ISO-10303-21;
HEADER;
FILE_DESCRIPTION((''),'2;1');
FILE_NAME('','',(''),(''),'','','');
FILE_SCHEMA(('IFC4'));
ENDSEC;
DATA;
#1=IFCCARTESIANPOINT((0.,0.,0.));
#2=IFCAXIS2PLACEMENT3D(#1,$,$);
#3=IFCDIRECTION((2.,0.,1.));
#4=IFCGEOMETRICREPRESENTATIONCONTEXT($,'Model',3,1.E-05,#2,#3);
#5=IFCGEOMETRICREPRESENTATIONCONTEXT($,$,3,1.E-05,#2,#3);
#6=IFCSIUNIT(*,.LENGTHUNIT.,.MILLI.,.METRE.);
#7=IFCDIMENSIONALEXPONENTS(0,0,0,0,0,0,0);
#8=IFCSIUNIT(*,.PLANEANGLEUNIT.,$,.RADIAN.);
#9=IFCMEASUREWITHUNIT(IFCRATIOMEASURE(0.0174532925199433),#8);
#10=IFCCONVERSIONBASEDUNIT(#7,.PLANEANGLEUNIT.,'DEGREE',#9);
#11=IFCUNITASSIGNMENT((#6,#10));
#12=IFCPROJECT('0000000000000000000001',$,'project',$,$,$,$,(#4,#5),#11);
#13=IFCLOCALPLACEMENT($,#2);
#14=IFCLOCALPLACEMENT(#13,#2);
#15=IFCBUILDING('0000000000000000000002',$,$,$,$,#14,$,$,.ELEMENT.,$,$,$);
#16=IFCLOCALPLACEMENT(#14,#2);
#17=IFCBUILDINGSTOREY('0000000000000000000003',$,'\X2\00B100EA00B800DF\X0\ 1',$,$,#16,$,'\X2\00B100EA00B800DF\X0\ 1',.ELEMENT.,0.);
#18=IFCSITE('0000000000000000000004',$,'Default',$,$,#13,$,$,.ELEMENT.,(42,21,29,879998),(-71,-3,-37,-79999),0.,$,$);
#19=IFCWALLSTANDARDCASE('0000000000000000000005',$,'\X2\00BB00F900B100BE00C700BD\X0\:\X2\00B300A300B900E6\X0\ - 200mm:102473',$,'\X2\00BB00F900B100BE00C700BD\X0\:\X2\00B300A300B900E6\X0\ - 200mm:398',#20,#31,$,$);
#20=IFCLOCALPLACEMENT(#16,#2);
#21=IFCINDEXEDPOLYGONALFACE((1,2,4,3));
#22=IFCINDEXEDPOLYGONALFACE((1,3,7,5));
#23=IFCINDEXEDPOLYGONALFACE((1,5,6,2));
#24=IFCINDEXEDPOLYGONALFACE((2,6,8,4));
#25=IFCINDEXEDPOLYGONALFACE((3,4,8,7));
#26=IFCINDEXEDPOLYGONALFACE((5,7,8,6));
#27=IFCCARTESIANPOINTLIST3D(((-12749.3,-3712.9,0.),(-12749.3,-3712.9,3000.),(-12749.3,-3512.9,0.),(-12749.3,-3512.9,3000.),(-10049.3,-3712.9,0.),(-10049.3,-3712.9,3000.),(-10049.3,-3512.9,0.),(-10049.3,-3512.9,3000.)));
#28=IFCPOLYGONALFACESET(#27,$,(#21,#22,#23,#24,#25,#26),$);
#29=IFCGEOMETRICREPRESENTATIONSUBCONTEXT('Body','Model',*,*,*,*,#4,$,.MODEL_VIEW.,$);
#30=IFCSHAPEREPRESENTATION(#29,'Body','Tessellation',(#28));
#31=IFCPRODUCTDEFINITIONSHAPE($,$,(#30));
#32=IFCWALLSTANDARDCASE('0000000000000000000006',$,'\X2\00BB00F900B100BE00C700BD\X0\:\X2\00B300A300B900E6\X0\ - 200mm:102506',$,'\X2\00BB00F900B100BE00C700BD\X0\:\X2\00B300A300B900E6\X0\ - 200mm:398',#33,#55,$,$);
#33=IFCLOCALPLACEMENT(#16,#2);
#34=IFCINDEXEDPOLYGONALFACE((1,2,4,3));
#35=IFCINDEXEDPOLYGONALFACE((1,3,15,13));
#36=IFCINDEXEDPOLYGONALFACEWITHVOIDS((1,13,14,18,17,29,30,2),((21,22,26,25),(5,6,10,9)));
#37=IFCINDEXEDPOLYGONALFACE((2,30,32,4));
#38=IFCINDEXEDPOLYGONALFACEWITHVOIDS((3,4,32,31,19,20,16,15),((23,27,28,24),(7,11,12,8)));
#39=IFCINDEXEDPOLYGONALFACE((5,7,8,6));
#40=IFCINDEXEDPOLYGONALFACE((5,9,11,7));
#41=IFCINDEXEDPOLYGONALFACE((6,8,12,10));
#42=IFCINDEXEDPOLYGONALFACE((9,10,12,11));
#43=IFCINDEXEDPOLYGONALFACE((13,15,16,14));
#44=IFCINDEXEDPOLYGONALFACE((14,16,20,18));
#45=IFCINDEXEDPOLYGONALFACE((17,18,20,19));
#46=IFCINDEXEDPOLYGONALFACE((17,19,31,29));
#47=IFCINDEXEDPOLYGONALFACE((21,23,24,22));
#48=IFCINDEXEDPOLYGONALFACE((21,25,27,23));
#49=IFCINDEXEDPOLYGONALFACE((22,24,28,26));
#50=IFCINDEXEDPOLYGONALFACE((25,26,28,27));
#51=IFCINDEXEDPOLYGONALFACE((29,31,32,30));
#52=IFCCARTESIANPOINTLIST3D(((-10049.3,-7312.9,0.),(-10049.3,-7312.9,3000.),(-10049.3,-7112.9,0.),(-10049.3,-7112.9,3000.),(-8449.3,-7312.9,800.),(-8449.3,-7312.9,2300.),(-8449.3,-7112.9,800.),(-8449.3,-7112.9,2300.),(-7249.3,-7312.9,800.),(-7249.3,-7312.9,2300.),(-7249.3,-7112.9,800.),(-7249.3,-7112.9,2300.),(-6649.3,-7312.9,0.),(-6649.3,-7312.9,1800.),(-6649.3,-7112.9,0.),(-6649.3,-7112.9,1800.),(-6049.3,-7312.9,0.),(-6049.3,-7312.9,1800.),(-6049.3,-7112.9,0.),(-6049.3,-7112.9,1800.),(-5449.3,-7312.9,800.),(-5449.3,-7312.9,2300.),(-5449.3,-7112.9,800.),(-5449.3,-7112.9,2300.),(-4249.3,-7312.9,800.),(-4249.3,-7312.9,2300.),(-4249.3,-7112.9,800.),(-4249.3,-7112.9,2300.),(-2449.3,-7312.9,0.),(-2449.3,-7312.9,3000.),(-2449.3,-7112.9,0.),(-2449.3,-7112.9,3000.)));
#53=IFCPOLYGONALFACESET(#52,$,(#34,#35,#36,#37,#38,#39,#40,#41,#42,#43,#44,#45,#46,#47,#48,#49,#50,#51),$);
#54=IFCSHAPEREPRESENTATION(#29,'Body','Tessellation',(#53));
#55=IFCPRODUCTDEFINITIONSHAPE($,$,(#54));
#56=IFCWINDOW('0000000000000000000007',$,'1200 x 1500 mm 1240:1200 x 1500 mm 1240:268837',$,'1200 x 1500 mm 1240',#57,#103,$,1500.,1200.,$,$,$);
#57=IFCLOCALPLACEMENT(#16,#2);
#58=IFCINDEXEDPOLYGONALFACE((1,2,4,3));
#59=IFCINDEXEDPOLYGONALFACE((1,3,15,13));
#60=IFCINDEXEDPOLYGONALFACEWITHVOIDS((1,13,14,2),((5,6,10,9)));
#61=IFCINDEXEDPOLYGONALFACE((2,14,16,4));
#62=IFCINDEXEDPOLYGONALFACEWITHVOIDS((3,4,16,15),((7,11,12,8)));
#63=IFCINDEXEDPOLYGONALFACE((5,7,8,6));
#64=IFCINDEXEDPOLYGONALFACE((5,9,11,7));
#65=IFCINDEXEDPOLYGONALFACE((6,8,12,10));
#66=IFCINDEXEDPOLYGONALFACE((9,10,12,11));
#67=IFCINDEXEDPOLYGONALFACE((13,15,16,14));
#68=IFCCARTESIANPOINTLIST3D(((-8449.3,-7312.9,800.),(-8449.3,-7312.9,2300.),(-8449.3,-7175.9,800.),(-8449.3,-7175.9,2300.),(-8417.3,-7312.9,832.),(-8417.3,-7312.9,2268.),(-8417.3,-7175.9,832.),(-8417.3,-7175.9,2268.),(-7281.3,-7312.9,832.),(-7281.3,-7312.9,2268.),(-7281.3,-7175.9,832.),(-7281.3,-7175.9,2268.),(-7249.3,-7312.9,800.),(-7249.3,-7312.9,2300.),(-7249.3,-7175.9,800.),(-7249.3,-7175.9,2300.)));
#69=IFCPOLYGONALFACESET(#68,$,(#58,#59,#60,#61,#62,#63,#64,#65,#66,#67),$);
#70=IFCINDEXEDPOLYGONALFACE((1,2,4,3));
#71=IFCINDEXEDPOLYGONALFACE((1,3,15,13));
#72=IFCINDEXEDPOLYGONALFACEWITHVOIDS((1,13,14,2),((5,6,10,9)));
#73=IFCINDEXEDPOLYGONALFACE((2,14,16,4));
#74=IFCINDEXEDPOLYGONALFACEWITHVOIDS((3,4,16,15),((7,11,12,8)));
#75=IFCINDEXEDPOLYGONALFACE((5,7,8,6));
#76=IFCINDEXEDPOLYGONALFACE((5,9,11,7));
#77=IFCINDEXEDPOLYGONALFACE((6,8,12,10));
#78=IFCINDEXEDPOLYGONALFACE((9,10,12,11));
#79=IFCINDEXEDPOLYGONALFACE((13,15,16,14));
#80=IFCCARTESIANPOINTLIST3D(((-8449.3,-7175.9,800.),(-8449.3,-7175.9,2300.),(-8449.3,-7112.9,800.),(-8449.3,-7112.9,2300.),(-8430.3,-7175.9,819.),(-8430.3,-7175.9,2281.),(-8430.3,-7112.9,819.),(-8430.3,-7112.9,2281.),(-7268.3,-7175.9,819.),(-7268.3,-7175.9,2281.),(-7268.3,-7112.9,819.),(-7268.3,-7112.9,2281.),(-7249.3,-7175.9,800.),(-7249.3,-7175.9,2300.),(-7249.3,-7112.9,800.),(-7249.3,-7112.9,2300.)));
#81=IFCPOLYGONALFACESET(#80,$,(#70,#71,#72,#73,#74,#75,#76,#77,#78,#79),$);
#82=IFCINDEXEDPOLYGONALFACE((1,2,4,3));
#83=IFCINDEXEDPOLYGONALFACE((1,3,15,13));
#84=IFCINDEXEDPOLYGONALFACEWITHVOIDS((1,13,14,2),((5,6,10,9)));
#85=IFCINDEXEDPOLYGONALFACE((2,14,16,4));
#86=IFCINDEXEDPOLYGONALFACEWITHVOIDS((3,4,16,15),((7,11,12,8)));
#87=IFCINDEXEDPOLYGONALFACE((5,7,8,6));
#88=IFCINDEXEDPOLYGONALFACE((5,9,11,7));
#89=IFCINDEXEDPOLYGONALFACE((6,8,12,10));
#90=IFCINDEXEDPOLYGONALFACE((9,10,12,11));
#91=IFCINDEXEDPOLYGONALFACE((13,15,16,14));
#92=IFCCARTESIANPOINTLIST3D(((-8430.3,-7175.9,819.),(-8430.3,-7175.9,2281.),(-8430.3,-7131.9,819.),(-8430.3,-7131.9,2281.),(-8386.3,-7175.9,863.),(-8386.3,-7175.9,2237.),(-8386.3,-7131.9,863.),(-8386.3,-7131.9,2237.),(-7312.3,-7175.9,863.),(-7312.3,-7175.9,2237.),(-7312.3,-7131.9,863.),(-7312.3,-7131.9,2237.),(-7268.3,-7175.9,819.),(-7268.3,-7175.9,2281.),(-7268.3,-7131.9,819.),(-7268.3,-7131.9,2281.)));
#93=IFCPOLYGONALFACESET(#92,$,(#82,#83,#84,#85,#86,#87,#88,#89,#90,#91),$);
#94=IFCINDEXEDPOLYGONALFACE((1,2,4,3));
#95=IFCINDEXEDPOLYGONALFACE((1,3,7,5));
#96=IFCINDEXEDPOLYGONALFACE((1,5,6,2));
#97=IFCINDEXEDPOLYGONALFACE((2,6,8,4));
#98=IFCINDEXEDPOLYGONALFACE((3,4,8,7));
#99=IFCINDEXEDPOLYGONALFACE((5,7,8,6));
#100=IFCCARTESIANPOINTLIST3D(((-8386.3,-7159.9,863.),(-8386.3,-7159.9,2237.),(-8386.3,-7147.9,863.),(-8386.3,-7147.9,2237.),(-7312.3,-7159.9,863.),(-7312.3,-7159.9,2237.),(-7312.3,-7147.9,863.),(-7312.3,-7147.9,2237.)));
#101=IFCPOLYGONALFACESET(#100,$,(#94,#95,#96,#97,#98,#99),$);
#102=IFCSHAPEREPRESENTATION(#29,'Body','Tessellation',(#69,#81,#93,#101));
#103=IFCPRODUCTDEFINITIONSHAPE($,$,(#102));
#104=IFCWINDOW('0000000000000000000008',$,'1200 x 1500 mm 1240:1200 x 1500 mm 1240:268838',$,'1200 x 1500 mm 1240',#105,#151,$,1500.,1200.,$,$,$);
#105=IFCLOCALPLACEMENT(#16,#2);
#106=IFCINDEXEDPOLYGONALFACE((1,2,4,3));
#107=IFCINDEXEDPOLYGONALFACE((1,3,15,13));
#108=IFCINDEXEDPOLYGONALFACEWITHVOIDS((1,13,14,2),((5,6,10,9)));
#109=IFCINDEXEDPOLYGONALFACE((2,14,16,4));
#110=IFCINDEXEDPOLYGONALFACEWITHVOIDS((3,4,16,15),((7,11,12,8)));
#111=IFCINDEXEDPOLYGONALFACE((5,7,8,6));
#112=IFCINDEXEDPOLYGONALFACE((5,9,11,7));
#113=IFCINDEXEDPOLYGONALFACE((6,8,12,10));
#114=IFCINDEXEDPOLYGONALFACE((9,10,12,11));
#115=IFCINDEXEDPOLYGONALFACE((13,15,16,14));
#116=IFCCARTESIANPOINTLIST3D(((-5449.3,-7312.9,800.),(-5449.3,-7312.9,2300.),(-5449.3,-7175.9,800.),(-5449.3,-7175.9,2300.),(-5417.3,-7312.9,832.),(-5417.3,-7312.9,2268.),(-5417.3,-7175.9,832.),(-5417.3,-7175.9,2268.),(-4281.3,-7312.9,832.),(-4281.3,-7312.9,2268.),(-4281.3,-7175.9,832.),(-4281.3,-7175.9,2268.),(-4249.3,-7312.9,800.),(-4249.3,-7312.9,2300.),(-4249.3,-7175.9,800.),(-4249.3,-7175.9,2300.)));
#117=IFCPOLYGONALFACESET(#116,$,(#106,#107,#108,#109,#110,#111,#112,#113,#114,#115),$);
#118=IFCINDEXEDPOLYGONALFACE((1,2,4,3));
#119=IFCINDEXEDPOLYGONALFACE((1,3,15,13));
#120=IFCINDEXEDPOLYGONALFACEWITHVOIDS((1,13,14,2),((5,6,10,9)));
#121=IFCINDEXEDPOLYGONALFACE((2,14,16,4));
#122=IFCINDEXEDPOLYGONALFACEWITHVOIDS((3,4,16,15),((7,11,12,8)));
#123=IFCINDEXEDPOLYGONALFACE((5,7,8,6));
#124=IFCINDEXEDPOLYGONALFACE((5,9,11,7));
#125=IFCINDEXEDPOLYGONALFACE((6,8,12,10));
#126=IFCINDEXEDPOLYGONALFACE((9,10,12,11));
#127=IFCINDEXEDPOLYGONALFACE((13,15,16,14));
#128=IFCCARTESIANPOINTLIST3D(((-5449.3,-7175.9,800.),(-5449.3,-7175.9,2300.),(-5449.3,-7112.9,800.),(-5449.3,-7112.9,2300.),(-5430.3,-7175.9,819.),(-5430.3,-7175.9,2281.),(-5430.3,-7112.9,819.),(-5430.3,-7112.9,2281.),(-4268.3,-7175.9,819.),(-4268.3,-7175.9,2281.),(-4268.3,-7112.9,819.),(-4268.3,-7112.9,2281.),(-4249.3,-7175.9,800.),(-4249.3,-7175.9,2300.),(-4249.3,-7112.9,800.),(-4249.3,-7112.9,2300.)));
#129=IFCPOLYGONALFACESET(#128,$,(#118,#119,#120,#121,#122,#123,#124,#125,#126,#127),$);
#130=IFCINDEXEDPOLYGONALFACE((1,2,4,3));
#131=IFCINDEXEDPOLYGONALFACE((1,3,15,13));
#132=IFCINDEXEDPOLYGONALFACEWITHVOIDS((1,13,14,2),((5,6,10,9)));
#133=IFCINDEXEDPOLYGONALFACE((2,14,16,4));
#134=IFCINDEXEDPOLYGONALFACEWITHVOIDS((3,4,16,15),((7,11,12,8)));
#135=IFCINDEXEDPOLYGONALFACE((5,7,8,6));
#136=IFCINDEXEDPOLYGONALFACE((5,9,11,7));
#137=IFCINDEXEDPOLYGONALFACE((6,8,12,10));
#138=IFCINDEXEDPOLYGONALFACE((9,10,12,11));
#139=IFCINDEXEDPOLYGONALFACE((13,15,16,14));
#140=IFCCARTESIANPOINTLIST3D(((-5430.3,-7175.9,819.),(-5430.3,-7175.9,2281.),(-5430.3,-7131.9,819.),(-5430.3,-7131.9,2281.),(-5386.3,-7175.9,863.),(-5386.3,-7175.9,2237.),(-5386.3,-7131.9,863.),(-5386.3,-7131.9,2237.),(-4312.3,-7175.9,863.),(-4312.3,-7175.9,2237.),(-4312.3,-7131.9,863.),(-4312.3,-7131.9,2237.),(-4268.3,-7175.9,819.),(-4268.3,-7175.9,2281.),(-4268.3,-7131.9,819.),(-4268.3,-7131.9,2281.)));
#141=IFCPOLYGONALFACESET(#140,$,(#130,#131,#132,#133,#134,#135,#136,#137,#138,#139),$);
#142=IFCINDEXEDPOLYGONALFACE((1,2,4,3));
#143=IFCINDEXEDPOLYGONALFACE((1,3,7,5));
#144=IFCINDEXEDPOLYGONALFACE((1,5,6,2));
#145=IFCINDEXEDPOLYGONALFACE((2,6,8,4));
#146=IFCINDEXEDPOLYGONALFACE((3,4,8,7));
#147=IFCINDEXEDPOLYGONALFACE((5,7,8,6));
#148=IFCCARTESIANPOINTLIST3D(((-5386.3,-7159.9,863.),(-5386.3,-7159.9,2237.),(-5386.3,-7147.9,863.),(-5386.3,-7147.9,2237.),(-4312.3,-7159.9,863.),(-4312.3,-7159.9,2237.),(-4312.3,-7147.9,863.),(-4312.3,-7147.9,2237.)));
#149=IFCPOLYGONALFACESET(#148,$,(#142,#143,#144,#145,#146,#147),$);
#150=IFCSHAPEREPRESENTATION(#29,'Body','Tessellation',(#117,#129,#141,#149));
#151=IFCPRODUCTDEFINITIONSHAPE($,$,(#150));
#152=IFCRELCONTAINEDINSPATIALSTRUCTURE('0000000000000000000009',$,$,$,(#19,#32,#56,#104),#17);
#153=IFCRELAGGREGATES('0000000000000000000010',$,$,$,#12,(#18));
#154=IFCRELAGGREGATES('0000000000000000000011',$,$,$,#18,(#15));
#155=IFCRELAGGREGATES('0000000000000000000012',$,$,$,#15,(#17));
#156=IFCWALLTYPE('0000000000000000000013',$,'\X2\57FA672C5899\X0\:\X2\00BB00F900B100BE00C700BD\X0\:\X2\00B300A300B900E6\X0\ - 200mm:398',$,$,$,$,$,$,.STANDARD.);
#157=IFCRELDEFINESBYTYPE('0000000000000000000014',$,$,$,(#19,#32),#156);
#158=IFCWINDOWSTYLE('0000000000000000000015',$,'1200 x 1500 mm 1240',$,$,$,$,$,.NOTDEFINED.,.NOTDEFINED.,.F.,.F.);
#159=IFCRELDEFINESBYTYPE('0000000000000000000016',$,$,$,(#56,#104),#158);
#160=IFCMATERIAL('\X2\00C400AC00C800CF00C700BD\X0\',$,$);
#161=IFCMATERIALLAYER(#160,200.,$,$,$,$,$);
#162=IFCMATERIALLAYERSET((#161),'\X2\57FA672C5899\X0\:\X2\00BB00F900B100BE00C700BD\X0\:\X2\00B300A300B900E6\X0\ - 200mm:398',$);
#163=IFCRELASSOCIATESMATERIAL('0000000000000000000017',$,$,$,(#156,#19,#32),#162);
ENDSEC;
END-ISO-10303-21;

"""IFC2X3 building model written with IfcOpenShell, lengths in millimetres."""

from ifc_helpers import new_model, entity, si_unit, converted_unit, direction, frame, frame_2d, origin, origin_2d_with_axis, place, context, subcontext, project, spatial, polyline, rectangle, outline, extrude, source, transform, mapped, material, layer, layer_set, layer_usage, type_object, type_shapes, element, fill, save


model = new_model("IFC2X3")

# Units and contexts
model_context = context("Model", 3, precision=1e-05, world=origin(), true_north=direction((2.0, 0.0, 1.0)))
context_of_model = context(None, 3, precision=1e-05, world=origin(), true_north=direction((2.0, 0.0, 1.0)))
body_context = subcontext(model_context, "Body", "Model", "MODEL_VIEW")
ifc_project = project(units=[si_unit("LENGTHUNIT", "METRE", prefix="MILLI"), converted_unit("PLANEANGLEUNIT", "DEGREE", entity("IfcRatioMeasure", 0.0174532925199433), si_unit("PLANEANGLEUNIT", "RADIAN"), dimensions=[0, 0, 0, 0, 0, 0, 0])], contexts=[model_context, context_of_model])

# Site, building, storey
site_placement = place(None, origin())
site = spatial("IfcSite", under=ifc_project, at=site_placement, Name="Default", CompositionType="ELEMENT", RefLatitude=(42, 21, 29, 879998), RefLongitude=(-71, -3, -37, -79999), RefElevation=0.0)
building_placement = place(site_placement, origin())
building = spatial("IfcBuilding", under=site, at=building_placement, CompositionType="ELEMENT")
storey_placement = place(building_placement, origin())
storey = spatial("IfcBuildingStorey", under=building, at=storey_placement, Name="±ê¸ß 1", LongName="±ê¸ß 1", CompositionType="ELEMENT", Elevation=0.0)

# Shared definitions
ifc_material_1 = material(Name="Ä¬ÈÏÇ½")
ifc_layer_1 = layer(ifc_material_1, 200.0)
ifc_layer_set_1 = layer_set([ifc_layer_1], Name="基本墙:»ù±¾Ç½:³£¹æ - 200mm:398")
wall_type = type_object("IfcWallType", Name="基本墙:»ù±¾Ç½:³£¹æ - 200mm:398", PredefinedType="STANDARD", material=ifc_layer_set_1)
window_style = type_object("IfcWindowStyle", Name="1200 x 1500 mm 1240", ConstructionType="NOTDEFINED", OperationType="NOTDEFINED", ParameterTakesPrecedence=False, Sizeable=False)
shared_shape = source(origin(), body_context, "Body", "SweptSolid", [
    extrude(outline(polyline([(-750.0, -600.0), (750.0, -600.0), (750.0, 600.0), (-750.0, 600.0), (-750.0, -600.0)]), holes=[polyline([(718.0, 568.0), (718.0, -568.0), (-718.0, -568.0), (-718.0, 568.0), (718.0, 568.0)])]), frame((600.0, -202.0, 750.0), z_axis=(0.0, 1.0, 0.0), x_axis=(0.0, 0.0, -1.0)), (0.0, 0.0, 1.0), 137.0),
    extrude(outline(polyline([(-750.0, -600.0), (750.0, -600.0), (750.0, 600.0), (-750.0, 600.0), (-750.0, -600.0)]), holes=[polyline([(731.0, 581.0), (731.0, -581.0), (-731.0, -581.0), (-731.0, 581.0), (731.0, 581.0)])]), frame((600.0, -65.0, 750.0), z_axis=(0.0, 1.0, 0.0), x_axis=(0.0, 0.0, -1.0)), (0.0, 0.0, 1.0), 63.0),
    extrude(outline(polyline([(-731.0, -581.0), (731.0, -581.0), (731.0, 581.0), (-731.0, 581.0), (-731.0, -581.0)]), holes=[polyline([(687.0, 537.0), (687.0, -537.0), (-687.0, -537.0), (-687.0, 537.0), (687.0, 537.0)])]), frame((600.0, -65.0, 750.0), z_axis=(0.0, 1.0, 0.0), x_axis=(0.0, 0.0, -1.0)), (0.0, 0.0, 1.0), 44.0),
    extrude(rectangle(XDim=1074.0, YDim=12.0, at=origin_2d_with_axis()), frame((600.0, -43.0, 63.0)), (0.0, 0.0, 1.0), 1374.0),
])
type_shapes(window_style, [shared_shape])

# Wall
ifc_layer_usage_1 = layer_usage(ifc_layer_set_1, "AXIS2", "NEGATIVE", 100.0)
wall_1_placement = place(storey_placement, frame((-12749.3, -3612.9, 0.0)))
element("IfcWallStandardCase", 1, at=wall_1_placement, inside=storey, type_object=wall_type, material=ifc_layer_usage_1, Name="»ù±¾Ç½:³£¹æ - 200mm:102473", ObjectType="»ù±¾Ç½:³£¹æ - 200mm:398", context=body_context, shape_type="SweptSolid", body=[
    extrude(rectangle(XDim=2700.0, YDim=200.0, at=frame_2d((1350.0, 0.0), x_axis=(-1.0, 0.0))), origin(), (0.0, 0.0, 1.0), 3000.0),
])

# Wall, openings, windows
ifc_layer_usage_2 = layer_usage(ifc_layer_set_1, "AXIS2", "NEGATIVE", 100.0)
wall_2_placement = place(storey_placement, frame((-10049.3, -7212.9, 0.0)))
wall_2 = element("IfcWallStandardCase", 2, at=wall_2_placement, inside=storey, type_object=wall_type, material=ifc_layer_usage_2, Name="»ù±¾Ç½:³£¹æ - 200mm:102506", ObjectType="»ù±¾Ç½:³£¹æ - 200mm:398", context=body_context, shape_type="SweptSolid", body=[
    extrude(rectangle(XDim=7600.0, YDim=200.0, at=frame_2d((3800.0, 0.0), x_axis=(-1.0, 0.0))), origin(), (0.0, 0.0, 1.0), 3000.0),
])
opening_1_placement = place(wall_2_placement, origin())
element("IfcOpeningElement", 3, at=opening_1_placement, cuts=wall_2, ObjectType="Opening", context=body_context, shape_type="SweptSolid", body=[
    extrude(rectangle(XDim=1800.0, YDim=600.0, at=origin_2d_with_axis()), frame((3700.0, -102.0, 900.0), z_axis=(0.0, 1.0, 0.0), x_axis=(0.0, 0.0, -1.0)), (0.0, 0.0, 1.0), 204.0),
])
opening_2_placement = place(wall_2_placement, origin())
opening_2 = element("IfcOpeningElement", 4, at=opening_2_placement, cuts=wall_2, ObjectType="Opening", context=body_context, shape_type="SweptSolid", body=[
    extrude(rectangle(XDim=1500.0, YDim=1200.0, at=frame_2d((0.0, 0.0), x_axis=(0.0, 1.0))), frame((2200.0, -102.0, 1550.0), z_axis=(0.0, 1.0, 0.0), x_axis=(1.0, 0.0, 0.0)), (0.0, 0.0, 1.0), 204.0),
])
opening_3_placement = place(wall_2_placement, origin())
opening_3 = element("IfcOpeningElement", 5, at=opening_3_placement, cuts=wall_2, ObjectType="Opening", context=body_context, shape_type="SweptSolid", body=[
    extrude(rectangle(XDim=1500.0, YDim=1200.0, at=frame_2d((0.0, 0.0), x_axis=(0.0, 1.0))), frame((5200.0, -102.0, 1550.0), z_axis=(0.0, 1.0, 0.0), x_axis=(1.0, 0.0, 0.0)), (0.0, 0.0, 1.0), 204.0),
])
window_1_placement = place(opening_2_placement, frame((1600.0, 102.0, 800.0)))
window_1 = element("IfcWindow", 6, at=window_1_placement, inside=storey, type_object=window_style, Name="1200 x 1500 mm 1240:1200 x 1500 mm 1240:268837", ObjectType="1200 x 1500 mm 1240", OverallHeight=1500.0, OverallWidth=1200.0, context=body_context, shape_type="MappedRepresentation", body=[
    mapped(shared_shape, transform((0.0, 0.0, 0.0), scale=1.0)),
])
fill(opening_2, window_1)
window_2_placement = place(opening_3_placement, frame((4600.0, 102.0, 800.0)))
window_2 = element("IfcWindow", 7, at=window_2_placement, inside=storey, type_object=window_style, Name="1200 x 1500 mm 1240:1200 x 1500 mm 1240:268838", ObjectType="1200 x 1500 mm 1240", OverallHeight=1500.0, OverallWidth=1200.0, context=body_context, shape_type="MappedRepresentation", body=[
    mapped(shared_shape, transform((0.0, 0.0, 0.0), scale=1.0)),
])
fill(opening_3, window_2)

save(model, "model.ifc")
